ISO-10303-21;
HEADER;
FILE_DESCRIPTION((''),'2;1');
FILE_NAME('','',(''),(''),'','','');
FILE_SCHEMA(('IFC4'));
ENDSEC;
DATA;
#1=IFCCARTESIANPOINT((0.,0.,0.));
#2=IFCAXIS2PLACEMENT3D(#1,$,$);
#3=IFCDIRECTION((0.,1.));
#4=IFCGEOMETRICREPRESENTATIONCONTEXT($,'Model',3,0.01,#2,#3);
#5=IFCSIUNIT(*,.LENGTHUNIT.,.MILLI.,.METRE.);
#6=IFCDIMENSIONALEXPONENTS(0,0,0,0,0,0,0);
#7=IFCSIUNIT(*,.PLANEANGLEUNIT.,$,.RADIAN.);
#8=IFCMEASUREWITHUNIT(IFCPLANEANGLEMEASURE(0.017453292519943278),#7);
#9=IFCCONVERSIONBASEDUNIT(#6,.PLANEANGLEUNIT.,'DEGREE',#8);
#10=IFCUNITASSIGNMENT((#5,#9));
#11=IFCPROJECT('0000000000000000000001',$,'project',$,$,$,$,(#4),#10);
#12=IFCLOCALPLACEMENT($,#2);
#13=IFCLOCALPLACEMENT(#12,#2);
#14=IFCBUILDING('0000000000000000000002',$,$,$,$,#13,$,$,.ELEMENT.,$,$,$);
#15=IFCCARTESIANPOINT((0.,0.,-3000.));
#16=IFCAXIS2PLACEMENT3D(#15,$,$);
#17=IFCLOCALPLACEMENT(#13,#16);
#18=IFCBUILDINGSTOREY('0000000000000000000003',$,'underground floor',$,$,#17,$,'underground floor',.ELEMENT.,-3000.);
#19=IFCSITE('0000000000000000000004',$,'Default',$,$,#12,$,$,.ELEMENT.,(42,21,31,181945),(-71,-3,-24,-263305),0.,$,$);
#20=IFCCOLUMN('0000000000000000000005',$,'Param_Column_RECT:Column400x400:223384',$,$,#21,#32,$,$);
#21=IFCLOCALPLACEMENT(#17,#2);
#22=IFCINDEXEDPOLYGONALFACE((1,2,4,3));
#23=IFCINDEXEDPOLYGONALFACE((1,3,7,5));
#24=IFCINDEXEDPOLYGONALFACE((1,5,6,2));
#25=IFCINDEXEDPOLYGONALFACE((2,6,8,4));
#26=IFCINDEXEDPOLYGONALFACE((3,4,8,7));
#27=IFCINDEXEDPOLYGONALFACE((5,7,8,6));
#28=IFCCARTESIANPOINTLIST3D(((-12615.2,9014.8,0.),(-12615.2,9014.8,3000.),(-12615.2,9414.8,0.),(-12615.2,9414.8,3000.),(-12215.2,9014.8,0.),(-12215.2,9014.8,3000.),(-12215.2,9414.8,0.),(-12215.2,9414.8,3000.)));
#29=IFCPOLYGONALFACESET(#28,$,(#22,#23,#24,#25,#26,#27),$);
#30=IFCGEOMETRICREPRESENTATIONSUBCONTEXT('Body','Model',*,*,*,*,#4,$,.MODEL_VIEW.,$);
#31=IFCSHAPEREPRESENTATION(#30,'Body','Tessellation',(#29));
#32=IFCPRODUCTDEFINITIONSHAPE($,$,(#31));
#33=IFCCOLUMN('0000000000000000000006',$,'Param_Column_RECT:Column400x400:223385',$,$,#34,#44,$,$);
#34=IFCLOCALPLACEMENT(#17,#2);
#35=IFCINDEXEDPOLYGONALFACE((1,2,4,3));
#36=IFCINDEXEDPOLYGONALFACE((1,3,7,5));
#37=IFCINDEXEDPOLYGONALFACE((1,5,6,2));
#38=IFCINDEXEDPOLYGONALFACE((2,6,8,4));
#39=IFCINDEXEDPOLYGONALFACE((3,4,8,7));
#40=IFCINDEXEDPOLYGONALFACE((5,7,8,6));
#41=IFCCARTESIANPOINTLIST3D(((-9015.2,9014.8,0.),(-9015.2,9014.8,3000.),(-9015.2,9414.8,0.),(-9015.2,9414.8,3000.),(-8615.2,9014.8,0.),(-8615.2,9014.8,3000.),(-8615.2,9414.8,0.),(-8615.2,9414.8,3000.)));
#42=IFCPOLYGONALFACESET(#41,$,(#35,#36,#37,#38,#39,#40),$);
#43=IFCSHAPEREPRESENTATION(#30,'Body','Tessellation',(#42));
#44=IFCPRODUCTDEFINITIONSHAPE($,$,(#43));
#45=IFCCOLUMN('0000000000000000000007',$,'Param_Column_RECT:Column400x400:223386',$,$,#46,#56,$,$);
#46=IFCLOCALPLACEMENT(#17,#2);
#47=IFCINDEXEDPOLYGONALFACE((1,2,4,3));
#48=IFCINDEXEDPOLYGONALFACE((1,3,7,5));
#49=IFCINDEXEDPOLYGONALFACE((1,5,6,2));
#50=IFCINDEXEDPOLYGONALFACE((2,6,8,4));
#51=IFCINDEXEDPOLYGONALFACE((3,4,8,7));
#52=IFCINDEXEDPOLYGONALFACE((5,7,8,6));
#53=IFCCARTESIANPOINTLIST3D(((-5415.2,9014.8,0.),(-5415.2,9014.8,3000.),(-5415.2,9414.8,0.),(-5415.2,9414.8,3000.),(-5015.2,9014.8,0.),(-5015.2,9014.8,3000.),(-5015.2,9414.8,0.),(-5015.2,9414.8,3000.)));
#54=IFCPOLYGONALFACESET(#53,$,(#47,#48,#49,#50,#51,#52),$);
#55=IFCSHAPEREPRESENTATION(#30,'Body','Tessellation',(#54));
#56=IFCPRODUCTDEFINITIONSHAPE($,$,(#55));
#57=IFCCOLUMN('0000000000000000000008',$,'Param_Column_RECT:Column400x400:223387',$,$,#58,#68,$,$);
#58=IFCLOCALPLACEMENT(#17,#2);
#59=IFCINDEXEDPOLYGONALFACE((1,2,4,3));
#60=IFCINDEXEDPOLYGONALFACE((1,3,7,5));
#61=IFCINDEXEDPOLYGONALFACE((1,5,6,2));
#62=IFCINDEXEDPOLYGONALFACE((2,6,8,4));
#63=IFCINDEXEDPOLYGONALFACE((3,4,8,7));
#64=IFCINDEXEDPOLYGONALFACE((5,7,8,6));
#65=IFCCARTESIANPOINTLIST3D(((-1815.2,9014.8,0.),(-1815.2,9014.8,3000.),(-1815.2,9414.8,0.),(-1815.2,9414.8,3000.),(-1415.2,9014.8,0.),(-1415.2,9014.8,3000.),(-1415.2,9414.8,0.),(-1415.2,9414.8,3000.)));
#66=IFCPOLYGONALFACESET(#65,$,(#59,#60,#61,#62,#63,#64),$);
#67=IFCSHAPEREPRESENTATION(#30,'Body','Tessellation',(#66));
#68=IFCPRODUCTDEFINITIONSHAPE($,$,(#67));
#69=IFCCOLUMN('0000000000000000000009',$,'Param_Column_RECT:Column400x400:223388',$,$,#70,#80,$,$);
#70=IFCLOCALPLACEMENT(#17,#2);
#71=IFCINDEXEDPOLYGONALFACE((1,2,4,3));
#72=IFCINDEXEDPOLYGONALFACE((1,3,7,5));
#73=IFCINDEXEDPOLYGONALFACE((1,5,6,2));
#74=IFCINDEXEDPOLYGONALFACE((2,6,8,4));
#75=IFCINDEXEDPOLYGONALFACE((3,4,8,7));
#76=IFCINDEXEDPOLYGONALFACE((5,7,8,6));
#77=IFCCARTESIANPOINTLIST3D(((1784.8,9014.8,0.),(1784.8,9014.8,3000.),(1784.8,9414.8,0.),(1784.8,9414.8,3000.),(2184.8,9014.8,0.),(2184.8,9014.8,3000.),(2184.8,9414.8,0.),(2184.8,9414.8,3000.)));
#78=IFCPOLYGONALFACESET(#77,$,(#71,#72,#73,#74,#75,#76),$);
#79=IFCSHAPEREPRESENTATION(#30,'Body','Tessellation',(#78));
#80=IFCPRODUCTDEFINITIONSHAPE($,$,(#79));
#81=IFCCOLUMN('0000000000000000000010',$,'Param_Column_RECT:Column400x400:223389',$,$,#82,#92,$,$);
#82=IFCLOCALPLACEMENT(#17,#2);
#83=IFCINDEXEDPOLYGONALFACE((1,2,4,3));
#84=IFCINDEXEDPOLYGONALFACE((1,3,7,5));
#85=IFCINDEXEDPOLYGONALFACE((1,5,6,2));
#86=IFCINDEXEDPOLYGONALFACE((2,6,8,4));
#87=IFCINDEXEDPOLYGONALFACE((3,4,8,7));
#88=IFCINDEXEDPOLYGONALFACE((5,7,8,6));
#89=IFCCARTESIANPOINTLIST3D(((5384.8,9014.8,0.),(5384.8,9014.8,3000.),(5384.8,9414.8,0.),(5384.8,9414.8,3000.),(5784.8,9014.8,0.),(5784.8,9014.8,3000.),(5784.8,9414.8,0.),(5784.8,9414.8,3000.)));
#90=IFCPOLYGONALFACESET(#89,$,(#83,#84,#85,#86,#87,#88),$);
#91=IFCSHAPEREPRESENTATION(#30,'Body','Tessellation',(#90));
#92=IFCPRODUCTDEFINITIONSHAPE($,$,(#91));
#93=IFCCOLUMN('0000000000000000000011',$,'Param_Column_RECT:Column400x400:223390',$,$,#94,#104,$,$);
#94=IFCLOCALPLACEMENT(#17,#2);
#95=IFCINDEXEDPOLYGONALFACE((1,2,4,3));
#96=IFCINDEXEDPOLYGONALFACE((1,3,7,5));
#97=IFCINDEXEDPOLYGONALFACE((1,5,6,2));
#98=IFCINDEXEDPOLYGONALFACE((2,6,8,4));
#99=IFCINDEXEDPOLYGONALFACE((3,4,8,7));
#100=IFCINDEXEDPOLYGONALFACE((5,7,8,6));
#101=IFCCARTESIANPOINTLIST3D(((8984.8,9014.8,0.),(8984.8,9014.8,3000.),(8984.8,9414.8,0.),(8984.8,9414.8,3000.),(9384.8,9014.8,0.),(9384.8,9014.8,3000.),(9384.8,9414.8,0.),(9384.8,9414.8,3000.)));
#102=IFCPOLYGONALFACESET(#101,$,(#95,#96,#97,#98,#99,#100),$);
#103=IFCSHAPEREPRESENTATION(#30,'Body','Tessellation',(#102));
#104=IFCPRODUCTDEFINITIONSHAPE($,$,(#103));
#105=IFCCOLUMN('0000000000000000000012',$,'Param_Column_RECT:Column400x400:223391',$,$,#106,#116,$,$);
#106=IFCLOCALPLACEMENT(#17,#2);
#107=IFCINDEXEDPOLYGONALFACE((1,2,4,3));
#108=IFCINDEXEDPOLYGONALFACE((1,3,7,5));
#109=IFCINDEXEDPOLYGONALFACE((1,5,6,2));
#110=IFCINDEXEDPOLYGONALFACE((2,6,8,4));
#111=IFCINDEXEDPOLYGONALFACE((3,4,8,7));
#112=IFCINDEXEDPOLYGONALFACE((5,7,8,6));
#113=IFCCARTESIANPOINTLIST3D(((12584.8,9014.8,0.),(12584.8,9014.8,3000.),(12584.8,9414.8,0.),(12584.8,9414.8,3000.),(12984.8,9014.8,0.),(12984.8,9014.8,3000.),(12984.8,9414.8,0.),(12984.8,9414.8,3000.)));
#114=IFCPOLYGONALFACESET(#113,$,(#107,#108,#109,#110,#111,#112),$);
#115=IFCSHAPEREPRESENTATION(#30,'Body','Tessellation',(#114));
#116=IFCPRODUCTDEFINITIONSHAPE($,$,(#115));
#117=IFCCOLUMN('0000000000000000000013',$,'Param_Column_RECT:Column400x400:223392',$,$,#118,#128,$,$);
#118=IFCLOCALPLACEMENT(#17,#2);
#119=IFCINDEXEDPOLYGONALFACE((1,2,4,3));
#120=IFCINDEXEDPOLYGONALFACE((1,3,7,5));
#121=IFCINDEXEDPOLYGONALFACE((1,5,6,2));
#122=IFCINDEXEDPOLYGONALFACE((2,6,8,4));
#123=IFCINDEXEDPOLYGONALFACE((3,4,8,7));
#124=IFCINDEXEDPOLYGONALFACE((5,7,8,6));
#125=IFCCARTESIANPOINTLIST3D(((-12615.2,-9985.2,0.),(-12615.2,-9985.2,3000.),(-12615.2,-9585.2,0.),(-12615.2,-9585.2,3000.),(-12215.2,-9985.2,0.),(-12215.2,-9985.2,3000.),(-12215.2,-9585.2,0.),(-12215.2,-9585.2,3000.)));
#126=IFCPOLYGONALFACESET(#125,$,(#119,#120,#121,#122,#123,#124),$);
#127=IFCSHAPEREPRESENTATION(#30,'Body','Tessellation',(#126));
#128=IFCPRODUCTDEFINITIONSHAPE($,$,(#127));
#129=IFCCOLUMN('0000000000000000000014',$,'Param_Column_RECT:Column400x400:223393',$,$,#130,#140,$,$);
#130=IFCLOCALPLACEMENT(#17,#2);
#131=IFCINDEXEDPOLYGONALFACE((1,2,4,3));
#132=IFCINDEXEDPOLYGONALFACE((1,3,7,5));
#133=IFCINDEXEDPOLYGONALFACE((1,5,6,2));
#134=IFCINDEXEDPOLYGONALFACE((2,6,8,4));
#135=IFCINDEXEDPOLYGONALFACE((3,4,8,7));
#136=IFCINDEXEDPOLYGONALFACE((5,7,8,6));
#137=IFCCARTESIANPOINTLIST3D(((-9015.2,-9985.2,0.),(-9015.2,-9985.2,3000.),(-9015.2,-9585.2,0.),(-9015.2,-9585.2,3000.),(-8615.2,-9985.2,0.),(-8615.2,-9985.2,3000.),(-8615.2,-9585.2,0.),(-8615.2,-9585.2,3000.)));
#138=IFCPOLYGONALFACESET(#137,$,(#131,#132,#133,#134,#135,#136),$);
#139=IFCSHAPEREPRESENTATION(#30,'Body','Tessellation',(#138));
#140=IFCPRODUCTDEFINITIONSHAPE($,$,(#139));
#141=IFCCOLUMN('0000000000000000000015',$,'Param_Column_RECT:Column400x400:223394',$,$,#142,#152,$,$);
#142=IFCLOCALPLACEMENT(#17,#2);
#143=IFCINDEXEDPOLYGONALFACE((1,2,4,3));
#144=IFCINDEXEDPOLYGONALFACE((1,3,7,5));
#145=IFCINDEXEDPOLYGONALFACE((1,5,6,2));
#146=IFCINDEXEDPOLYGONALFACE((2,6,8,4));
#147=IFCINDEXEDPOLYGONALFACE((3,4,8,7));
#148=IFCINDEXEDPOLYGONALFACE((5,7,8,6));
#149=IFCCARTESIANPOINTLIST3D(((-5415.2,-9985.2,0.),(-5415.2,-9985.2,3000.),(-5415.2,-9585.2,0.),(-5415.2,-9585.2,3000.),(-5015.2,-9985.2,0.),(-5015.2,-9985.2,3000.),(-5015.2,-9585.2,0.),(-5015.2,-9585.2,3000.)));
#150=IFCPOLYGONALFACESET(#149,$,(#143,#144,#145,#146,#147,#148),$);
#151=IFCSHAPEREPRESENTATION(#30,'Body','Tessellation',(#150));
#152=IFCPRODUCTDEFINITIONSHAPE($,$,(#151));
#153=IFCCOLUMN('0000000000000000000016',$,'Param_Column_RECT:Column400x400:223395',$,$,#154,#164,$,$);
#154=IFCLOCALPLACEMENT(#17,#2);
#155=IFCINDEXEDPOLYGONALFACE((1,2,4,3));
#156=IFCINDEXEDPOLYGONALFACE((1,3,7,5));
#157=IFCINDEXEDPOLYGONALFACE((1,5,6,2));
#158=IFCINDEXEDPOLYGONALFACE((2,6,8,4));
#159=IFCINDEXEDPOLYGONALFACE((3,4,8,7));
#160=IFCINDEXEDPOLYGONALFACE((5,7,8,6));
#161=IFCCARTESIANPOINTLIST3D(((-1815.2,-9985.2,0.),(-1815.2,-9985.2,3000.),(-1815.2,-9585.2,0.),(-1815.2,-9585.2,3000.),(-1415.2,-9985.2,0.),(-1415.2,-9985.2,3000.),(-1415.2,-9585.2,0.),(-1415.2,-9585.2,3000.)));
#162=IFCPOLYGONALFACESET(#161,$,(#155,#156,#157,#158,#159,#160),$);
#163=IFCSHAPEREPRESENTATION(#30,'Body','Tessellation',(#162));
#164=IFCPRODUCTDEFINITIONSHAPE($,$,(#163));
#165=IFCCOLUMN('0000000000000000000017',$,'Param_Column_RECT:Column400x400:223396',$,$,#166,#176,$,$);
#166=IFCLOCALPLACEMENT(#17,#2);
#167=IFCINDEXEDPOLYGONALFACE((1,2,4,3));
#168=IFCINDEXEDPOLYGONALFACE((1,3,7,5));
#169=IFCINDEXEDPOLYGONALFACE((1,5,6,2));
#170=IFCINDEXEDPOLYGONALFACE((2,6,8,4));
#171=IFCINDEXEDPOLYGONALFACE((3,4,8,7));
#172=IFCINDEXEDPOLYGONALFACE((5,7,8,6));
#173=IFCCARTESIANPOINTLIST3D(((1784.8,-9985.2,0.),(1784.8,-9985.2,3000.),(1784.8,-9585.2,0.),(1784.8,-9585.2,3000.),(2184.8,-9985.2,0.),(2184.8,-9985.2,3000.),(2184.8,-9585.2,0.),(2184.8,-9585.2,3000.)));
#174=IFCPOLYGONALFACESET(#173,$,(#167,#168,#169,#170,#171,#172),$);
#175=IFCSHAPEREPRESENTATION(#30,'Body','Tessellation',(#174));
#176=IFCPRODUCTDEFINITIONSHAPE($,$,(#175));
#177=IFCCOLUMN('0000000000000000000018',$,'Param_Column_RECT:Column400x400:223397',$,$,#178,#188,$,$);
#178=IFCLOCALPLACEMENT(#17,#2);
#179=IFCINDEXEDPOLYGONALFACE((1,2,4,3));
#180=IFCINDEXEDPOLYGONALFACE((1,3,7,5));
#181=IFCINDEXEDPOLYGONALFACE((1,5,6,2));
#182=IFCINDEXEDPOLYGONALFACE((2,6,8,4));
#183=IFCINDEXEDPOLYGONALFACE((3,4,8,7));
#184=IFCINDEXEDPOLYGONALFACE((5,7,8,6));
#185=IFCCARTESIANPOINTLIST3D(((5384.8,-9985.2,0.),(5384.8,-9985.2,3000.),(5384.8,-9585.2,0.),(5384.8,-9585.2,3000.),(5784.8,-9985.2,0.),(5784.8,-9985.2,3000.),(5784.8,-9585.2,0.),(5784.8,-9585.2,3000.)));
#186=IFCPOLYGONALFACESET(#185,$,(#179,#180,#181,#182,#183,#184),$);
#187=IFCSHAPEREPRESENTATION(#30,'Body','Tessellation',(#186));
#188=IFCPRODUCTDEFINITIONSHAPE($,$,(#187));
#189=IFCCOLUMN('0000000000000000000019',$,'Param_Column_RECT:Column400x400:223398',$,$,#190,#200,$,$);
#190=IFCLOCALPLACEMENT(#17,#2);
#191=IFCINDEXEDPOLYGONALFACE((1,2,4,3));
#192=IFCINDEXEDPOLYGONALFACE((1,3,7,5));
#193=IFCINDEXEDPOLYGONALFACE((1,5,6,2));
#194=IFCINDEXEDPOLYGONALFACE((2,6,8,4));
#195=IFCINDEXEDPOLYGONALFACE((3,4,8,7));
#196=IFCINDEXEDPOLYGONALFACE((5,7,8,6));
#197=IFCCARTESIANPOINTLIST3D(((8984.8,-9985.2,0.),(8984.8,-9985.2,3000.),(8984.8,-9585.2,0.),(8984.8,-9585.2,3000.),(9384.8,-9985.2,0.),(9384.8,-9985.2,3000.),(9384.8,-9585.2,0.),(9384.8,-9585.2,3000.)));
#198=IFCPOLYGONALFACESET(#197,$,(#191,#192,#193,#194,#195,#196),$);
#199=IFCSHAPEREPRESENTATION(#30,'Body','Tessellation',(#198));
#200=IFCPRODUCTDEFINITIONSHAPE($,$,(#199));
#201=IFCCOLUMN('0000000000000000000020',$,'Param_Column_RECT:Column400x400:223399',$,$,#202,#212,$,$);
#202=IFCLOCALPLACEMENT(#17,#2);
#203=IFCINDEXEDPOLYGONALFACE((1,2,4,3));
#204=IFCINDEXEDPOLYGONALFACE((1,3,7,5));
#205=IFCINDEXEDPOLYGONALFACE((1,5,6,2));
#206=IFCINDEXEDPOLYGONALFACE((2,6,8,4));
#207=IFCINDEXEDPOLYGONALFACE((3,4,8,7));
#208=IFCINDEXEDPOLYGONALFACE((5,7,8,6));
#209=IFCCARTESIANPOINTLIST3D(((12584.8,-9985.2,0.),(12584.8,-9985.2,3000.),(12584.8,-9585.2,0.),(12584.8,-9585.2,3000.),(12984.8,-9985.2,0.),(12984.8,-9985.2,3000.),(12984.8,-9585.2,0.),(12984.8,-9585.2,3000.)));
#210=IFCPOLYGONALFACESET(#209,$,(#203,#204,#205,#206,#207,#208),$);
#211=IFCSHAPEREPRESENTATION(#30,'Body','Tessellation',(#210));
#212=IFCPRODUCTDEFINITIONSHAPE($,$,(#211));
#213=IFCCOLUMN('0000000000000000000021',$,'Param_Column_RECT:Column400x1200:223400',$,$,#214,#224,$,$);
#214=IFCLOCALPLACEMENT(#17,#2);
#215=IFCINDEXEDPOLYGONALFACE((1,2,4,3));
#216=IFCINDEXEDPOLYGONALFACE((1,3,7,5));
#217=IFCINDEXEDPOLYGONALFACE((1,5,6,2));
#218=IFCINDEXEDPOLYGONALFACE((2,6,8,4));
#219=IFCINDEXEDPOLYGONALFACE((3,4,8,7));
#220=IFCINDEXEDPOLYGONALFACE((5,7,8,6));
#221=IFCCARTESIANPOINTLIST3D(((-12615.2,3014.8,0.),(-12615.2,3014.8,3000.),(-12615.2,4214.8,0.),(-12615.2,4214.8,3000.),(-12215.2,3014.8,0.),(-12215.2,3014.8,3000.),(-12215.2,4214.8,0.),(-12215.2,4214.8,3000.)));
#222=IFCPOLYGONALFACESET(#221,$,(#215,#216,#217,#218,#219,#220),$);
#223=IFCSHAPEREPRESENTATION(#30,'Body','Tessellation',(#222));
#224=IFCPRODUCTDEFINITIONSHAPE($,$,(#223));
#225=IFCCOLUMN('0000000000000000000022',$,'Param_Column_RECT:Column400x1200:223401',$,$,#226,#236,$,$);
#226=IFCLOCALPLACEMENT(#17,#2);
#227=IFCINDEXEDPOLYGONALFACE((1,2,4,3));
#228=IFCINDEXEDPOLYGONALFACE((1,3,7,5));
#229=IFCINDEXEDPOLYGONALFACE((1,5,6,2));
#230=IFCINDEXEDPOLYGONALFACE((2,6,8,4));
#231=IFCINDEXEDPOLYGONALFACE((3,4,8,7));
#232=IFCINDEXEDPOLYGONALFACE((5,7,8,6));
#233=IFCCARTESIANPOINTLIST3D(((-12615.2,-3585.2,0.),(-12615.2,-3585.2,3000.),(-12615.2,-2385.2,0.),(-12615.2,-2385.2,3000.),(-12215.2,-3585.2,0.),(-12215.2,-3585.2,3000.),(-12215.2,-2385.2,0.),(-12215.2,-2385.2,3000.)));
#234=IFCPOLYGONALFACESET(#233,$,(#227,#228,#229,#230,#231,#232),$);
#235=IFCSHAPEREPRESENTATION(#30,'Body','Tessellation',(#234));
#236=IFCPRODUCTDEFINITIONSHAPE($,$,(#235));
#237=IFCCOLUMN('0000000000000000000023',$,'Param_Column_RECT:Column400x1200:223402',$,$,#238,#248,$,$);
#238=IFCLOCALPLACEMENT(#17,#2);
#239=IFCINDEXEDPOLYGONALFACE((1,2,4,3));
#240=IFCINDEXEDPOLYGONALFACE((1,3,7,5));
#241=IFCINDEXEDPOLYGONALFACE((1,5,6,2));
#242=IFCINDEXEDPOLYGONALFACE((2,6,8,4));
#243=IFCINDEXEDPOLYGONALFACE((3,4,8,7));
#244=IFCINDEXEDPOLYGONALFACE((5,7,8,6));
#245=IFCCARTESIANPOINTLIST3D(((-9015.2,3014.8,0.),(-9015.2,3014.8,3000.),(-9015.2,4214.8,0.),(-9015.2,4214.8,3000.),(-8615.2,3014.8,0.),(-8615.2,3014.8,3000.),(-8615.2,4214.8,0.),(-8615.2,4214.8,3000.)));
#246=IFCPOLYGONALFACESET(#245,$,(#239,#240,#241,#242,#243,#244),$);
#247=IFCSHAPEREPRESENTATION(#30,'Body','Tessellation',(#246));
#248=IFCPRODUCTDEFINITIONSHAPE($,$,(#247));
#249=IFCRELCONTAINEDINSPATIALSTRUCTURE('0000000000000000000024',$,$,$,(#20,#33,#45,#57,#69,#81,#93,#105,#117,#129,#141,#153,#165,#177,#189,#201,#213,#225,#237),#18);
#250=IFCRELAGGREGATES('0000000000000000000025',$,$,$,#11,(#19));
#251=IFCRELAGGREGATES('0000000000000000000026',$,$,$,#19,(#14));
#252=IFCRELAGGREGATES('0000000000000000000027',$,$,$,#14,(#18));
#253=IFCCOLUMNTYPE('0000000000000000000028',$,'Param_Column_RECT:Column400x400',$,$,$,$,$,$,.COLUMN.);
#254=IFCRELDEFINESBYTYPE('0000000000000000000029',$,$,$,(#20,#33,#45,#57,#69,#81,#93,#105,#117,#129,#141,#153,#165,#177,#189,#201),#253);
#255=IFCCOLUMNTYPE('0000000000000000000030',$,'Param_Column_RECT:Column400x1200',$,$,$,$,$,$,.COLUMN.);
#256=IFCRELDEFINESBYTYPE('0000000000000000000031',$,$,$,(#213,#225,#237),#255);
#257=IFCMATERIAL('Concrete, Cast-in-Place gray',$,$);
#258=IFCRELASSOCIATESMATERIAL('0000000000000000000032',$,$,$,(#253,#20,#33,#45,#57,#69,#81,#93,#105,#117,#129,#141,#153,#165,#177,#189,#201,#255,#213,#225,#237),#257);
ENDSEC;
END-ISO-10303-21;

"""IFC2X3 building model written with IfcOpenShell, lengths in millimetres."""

from ifc_helpers import new_model, entity, si_unit, converted_unit, direction, frame, origin, origin_2d_with_axis, place, context, subcontext, project, spatial, rectangle, extrude, source, transform, mapped, material, type_object, type_shapes, element, save


model = new_model("IFC2X3")

# Units and contexts
model_context = context("Model", 3, precision=0.01, world=origin(), true_north=direction((0.0, 1.0)))
body_context = subcontext(model_context, "Body", "Model", "MODEL_VIEW")
ifc_project = project(units=[si_unit("LENGTHUNIT", "METRE", prefix="MILLI"), converted_unit("PLANEANGLEUNIT", "DEGREE", entity("IfcPlaneAngleMeasure", 0.017453292519943278), si_unit("PLANEANGLEUNIT", "RADIAN"), dimensions=[0, 0, 0, 0, 0, 0, 0])], contexts=[model_context])

# Site, building, storey
site_placement = place(None, origin())
site = spatial("IfcSite", under=ifc_project, at=site_placement, Name="Default", CompositionType="ELEMENT", RefLatitude=(42, 21, 31, 181945), RefLongitude=(-71, -3, -24, -263305), RefElevation=0.0)
building_placement = place(site_placement, origin())
building = spatial("IfcBuilding", under=site, at=building_placement, CompositionType="ELEMENT")
storey_placement = place(building_placement, frame((0.0, 0.0, -3000.0)))
storey = spatial("IfcBuildingStorey", under=building, at=storey_placement, Name="underground floor", LongName="underground floor", CompositionType="ELEMENT", Elevation=-3000.0)

# Columns
ifc_material_1 = material(Name="Concrete, Cast-in-Place gray")
column_type_1 = type_object("IfcColumnType", Name="Param_Column_RECT:Column400x400", PredefinedType="COLUMN", material=ifc_material_1)
shared_shape_1 = source(origin(), body_context, "Body", "SweptSolid", [
    extrude(rectangle(XDim=400.0, YDim=400.0, at=origin_2d_with_axis()), frame((0.0, 0.0, -3000.0), z_axis=(0.0, 0.0, 1.0), x_axis=(-1.0, 0.0, 0.0)), (0.0, 0.0, 1.0), 3000.0),
])
type_shapes(column_type_1, [shared_shape_1])
for number, where, name in (
    (1, (-12415.2, 9214.8, 3000.0), "Param_Column_RECT:Column400x400:223384"),
    (2, (-8815.2, 9214.8, 3000.0), "Param_Column_RECT:Column400x400:223385"),
    (3, (-5215.2, 9214.8, 3000.0), "Param_Column_RECT:Column400x400:223386"),
    (4, (-1615.2, 9214.8, 3000.0), "Param_Column_RECT:Column400x400:223387"),
    (5, (1984.8, 9214.8, 3000.0), "Param_Column_RECT:Column400x400:223388"),
    (6, (5584.8, 9214.8, 3000.0), "Param_Column_RECT:Column400x400:223389"),
    (7, (9184.8, 9214.8, 3000.0), "Param_Column_RECT:Column400x400:223390"),
    (8, (12784.8, 9214.8, 3000.0), "Param_Column_RECT:Column400x400:223391"),
    (9, (-12415.2, -9785.2, 3000.0), "Param_Column_RECT:Column400x400:223392"),
    (10, (-8815.2, -9785.2, 3000.0), "Param_Column_RECT:Column400x400:223393"),
    (11, (-5215.2, -9785.2, 3000.0), "Param_Column_RECT:Column400x400:223394"),
    (12, (-1615.2, -9785.2, 3000.0), "Param_Column_RECT:Column400x400:223395"),
    (13, (1984.8, -9785.2, 3000.0), "Param_Column_RECT:Column400x400:223396"),
    (14, (5584.8, -9785.2, 3000.0), "Param_Column_RECT:Column400x400:223397"),
    (15, (9184.8, -9785.2, 3000.0), "Param_Column_RECT:Column400x400:223398"),
    (16, (12784.8, -9785.2, 3000.0), "Param_Column_RECT:Column400x400:223399"),
):
    element("IfcColumn", number, at=place(storey_placement, frame(where)), inside=storey, type_object=column_type_1, material=ifc_material_1, Name=name, context=body_context, shape_type="MappedRepresentation", body=[
        mapped(shared_shape_1, transform((0.0, 0.0, 0.0), scale=1.0)),
    ])
column_type_2 = type_object("IfcColumnType", Name="Param_Column_RECT:Column400x1200", PredefinedType="COLUMN", material=ifc_material_1)
shared_shape_2 = source(origin(), body_context, "Body", "SweptSolid", [
    extrude(rectangle(XDim=400.0, YDim=1200.0, at=origin_2d_with_axis()), frame((0.0, 0.0, -3000.0), z_axis=(0.0, 0.0, 1.0), x_axis=(-1.0, 0.0, 0.0)), (0.0, 0.0, 1.0), 3000.0),
])
type_shapes(column_type_2, [shared_shape_2])
for number, where, name in (
    (17, (-12415.2, 3614.8, 3000.0), "Param_Column_RECT:Column400x1200:223400"),
    (18, (-12415.2, -2985.2, 3000.0), "Param_Column_RECT:Column400x1200:223401"),
    (19, (-8815.2, 3614.8, 3000.0), "Param_Column_RECT:Column400x1200:223402"),
):
    element("IfcColumn", number, at=place(storey_placement, frame(where)), inside=storey, type_object=column_type_2, material=ifc_material_1, Name=name, context=body_context, shape_type="MappedRepresentation", body=[
        mapped(shared_shape_2, transform((0.0, 0.0, 0.0), scale=1.0)),
    ])

save(model, "model.ifc")
